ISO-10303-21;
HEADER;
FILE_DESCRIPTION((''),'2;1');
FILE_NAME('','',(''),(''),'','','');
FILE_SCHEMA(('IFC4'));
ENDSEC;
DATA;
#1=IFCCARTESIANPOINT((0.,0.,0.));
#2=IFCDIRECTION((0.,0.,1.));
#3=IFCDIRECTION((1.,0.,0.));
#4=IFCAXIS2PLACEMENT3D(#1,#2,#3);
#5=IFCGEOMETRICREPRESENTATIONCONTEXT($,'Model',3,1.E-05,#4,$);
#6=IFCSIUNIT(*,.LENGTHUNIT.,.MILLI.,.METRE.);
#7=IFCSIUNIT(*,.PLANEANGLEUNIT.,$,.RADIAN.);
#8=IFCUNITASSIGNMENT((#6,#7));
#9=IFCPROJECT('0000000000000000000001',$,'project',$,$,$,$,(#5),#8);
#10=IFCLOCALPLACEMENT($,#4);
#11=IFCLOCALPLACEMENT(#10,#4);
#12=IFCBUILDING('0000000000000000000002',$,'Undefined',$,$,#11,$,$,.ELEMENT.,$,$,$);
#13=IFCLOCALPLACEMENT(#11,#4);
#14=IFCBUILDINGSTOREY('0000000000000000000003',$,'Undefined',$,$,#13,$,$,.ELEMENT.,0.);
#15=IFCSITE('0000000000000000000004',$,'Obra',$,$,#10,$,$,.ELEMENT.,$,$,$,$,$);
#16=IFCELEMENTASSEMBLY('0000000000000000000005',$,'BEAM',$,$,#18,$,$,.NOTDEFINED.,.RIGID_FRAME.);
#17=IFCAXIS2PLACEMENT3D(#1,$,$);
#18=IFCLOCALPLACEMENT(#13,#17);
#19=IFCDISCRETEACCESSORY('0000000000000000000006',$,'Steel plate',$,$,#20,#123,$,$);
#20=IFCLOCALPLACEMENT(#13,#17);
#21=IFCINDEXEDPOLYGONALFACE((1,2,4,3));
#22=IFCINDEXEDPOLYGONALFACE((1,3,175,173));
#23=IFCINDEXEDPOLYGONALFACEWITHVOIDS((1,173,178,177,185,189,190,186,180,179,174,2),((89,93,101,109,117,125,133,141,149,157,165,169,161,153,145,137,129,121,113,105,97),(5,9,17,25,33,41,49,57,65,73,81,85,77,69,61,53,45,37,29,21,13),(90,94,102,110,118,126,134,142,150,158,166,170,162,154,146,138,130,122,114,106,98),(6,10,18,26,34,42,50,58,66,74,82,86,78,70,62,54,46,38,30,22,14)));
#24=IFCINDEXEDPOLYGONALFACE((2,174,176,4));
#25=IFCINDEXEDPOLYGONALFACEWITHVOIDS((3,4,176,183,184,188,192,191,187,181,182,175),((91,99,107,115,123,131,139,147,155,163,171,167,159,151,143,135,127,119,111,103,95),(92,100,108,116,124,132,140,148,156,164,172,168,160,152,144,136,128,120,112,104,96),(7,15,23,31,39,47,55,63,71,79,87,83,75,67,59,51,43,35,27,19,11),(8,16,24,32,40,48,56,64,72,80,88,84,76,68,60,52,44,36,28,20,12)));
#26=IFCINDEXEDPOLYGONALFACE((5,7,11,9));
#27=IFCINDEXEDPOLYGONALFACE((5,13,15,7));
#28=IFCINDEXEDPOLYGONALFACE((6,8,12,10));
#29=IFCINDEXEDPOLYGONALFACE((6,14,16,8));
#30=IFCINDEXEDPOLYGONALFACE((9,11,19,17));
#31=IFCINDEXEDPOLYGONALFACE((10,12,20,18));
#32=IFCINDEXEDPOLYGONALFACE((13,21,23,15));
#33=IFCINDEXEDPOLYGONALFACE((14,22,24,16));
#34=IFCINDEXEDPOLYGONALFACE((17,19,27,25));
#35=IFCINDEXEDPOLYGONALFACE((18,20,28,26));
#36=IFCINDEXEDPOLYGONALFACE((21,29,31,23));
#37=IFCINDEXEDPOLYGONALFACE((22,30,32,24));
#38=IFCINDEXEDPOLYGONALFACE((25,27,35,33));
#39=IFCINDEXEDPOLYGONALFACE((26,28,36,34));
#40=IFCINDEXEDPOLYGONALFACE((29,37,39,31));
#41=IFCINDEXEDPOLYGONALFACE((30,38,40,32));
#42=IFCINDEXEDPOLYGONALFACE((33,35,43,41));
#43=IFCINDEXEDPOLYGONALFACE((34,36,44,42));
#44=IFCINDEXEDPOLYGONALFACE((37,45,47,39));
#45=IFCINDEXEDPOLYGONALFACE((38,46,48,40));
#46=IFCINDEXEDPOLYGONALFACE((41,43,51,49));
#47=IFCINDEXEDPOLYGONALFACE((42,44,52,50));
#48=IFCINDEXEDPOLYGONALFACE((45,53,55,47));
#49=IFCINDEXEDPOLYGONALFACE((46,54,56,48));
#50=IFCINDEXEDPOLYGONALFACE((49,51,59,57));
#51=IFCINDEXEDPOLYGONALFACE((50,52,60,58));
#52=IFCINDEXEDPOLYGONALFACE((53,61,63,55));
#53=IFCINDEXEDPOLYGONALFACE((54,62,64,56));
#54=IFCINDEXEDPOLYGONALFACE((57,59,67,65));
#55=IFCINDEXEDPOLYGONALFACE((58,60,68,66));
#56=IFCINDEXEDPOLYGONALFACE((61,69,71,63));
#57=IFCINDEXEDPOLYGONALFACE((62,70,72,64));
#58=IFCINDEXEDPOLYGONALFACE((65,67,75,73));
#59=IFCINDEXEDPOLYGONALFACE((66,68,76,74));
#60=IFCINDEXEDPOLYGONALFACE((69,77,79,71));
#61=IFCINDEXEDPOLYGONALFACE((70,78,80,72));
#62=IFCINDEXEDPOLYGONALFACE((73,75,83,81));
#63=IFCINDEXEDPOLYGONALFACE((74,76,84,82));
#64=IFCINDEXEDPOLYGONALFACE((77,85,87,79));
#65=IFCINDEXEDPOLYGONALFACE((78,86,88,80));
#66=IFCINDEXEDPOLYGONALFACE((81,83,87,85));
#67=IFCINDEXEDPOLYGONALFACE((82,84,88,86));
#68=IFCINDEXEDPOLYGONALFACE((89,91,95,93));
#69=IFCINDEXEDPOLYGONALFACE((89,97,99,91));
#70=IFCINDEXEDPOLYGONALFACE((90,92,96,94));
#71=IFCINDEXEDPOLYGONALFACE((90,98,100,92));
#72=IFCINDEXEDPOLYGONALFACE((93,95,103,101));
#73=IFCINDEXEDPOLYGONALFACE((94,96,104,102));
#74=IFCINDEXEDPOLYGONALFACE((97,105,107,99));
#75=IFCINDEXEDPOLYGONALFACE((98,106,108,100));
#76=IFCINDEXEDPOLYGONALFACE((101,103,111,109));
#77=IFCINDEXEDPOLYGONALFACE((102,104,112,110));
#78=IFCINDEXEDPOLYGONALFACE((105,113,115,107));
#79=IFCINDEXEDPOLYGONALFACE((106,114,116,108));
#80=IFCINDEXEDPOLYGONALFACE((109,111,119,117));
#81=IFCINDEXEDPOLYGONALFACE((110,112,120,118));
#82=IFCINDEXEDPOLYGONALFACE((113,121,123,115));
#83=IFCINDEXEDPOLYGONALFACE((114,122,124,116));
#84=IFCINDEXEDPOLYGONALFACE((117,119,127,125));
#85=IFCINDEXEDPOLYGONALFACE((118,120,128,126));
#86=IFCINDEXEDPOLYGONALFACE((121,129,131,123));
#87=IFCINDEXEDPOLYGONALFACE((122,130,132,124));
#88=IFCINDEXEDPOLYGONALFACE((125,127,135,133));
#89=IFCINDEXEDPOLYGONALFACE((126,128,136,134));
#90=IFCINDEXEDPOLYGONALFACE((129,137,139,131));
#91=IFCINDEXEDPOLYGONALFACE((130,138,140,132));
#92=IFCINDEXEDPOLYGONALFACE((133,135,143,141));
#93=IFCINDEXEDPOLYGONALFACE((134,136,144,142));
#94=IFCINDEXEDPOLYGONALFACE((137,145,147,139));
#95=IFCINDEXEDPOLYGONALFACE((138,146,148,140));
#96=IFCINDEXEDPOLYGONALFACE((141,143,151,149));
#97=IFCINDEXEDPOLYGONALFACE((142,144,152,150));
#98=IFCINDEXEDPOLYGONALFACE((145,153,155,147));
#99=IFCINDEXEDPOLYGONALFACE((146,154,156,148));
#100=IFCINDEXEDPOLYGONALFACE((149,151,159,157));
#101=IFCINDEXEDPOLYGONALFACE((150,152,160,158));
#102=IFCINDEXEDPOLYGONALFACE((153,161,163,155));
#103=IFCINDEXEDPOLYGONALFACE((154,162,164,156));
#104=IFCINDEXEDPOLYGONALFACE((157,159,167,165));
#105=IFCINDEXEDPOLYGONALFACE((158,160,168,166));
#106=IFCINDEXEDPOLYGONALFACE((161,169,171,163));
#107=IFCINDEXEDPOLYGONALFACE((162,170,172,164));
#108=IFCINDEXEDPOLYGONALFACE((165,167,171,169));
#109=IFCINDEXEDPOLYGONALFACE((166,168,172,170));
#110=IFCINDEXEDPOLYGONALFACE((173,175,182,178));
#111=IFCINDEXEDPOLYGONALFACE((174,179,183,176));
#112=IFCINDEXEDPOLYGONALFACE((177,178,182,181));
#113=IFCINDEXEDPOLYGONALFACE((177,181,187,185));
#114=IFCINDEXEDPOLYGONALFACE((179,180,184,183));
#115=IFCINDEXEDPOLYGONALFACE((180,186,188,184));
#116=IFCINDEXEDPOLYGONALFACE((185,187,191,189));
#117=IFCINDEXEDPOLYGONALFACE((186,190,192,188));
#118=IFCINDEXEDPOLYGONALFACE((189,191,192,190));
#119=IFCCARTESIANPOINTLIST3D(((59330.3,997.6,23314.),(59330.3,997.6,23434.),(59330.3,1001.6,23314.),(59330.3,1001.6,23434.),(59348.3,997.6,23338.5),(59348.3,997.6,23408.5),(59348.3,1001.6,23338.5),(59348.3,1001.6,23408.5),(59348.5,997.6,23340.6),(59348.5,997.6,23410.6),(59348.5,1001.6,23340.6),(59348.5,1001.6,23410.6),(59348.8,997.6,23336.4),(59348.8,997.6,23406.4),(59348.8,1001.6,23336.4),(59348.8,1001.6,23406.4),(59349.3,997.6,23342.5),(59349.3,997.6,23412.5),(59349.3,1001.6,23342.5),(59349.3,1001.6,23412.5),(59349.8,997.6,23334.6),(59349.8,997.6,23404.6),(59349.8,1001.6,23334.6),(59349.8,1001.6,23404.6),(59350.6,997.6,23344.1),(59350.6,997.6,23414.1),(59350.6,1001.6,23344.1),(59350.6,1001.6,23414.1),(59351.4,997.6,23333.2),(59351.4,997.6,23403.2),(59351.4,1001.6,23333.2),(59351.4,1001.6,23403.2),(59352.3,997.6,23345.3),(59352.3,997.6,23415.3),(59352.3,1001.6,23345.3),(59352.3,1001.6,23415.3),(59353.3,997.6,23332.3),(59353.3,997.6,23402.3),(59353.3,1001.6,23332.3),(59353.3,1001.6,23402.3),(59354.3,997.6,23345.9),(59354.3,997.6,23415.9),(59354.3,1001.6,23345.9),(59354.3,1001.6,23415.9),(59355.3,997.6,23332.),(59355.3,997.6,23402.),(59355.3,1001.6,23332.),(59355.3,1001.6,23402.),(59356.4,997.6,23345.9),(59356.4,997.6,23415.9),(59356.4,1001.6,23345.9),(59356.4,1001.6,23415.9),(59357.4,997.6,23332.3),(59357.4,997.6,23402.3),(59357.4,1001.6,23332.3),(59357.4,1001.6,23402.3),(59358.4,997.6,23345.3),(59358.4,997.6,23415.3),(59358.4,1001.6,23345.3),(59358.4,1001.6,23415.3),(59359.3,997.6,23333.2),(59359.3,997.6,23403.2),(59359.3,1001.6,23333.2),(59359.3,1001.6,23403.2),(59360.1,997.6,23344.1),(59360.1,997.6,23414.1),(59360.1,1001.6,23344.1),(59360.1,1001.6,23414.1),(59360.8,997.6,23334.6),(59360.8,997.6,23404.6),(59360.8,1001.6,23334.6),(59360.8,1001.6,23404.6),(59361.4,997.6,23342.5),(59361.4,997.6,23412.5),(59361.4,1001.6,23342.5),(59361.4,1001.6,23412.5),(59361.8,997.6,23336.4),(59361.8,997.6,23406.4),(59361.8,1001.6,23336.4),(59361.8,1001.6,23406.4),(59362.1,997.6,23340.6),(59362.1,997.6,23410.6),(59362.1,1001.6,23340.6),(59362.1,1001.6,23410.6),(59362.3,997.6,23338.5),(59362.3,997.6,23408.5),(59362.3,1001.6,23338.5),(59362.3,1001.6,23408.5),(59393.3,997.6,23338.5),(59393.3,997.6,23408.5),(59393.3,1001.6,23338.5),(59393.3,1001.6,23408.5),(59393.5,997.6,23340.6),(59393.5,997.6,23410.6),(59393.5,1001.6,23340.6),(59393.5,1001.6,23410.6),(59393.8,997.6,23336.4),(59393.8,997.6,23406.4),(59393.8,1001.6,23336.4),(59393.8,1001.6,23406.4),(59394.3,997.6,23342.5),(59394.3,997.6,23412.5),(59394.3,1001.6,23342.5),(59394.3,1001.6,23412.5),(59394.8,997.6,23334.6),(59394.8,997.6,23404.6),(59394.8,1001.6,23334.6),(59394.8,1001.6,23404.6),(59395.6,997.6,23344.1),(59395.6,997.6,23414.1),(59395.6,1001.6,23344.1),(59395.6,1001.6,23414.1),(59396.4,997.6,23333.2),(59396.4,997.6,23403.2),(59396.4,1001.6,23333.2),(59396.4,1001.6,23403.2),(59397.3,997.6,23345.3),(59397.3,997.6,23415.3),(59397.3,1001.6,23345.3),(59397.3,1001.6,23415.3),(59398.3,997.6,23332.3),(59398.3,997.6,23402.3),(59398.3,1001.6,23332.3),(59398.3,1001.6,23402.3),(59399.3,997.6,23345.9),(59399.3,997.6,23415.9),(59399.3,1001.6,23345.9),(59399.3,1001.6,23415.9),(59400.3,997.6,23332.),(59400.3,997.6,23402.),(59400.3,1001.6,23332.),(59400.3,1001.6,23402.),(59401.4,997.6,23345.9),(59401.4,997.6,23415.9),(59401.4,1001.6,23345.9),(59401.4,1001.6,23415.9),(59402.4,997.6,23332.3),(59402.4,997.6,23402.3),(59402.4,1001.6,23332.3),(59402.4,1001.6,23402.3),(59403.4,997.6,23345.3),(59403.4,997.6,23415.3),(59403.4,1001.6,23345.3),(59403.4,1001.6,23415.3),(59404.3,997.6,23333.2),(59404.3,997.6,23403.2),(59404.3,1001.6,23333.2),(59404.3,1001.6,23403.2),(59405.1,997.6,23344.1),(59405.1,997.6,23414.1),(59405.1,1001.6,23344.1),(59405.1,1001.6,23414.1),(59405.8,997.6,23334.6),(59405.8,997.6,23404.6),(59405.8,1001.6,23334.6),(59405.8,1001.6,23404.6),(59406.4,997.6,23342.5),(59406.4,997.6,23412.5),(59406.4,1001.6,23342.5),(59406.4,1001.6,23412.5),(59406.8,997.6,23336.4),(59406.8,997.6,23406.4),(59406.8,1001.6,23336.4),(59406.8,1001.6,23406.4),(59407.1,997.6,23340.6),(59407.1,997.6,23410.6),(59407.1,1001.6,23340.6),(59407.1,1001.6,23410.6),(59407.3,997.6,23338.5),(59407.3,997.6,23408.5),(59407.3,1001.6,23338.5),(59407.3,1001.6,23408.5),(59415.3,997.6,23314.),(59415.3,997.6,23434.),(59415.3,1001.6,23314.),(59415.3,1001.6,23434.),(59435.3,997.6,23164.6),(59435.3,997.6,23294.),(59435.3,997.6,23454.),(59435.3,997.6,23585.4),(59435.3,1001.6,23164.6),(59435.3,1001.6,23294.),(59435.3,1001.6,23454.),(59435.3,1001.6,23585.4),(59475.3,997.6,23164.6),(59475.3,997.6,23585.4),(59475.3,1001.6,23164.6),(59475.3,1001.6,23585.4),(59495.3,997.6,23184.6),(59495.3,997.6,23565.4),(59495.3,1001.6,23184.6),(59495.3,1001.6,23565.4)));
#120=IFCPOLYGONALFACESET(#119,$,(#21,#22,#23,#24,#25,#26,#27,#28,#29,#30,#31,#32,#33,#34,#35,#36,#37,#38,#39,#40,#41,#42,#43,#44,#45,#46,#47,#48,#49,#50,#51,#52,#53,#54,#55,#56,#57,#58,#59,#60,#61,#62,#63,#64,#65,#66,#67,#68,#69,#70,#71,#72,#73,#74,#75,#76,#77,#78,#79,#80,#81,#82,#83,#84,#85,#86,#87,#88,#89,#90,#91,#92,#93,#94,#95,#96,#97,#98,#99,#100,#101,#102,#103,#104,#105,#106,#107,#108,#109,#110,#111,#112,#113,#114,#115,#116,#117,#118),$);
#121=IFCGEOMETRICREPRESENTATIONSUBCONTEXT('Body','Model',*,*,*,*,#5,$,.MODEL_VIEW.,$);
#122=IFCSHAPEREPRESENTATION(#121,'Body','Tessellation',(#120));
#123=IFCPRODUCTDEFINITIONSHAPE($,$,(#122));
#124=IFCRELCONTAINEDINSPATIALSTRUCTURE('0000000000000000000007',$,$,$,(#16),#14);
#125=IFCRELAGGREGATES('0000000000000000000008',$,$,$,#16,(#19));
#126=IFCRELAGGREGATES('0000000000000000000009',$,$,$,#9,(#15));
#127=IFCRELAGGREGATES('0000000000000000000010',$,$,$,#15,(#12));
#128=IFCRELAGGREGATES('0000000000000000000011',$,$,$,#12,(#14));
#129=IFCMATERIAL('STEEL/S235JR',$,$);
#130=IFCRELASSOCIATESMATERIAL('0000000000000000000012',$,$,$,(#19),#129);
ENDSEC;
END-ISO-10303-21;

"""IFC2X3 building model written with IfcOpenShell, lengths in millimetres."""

from ifc_helpers import new_model, si_unit, frame, origin_with_axes, origin_2d_with_axis, place, context, subcontext, project, spatial, polyline, circle, outline, extrude, source, transform, mapped, material, element, aggregate, save


model = new_model("IFC2X3")

# Units and contexts
model_context = context("Model", 3, precision=1e-05, world=origin_with_axes())
body_context = subcontext(model_context, "Body", "Model", "MODEL_VIEW")
ifc_project = project(units=[si_unit("LENGTHUNIT", "METRE", prefix="MILLI"), si_unit("PLANEANGLEUNIT", "RADIAN")], contexts=[model_context])

# Site, building, storey
site_placement = place(None, origin_with_axes())
site = spatial("IfcSite", under=ifc_project, at=site_placement, Name="Obra", CompositionType="ELEMENT")
building_placement = place(site_placement, origin_with_axes())
building = spatial("IfcBuilding", under=site, at=building_placement, Name="Undefined", CompositionType="ELEMENT")
storey_placement = place(building_placement, origin_with_axes())
storey = spatial("IfcBuildingStorey", under=building, at=storey_placement, Name="Undefined", CompositionType="ELEMENT", Elevation=0.0)

# Element assembly
assembly_1_placement = place(storey_placement, origin_with_axes())
assembly_1 = element("IfcElementAssembly", 1, at=assembly_1_placement, inside=storey, Name="BEAM", AssemblyPlace="NOTDEFINED", PredefinedType="RIGID_FRAME")
ifc_material_1 = material(Name="STEEL/S235JR")

# Discrete accessory, opening
discrete_accessory_1_placement = place(assembly_1_placement, frame((59495.3, 999.6, 23184.6), z_axis=(0.000014, 1.0, 0.0), x_axis=(-0.707107, 0.00001, -0.707107)))
discrete_accessory_1 = element("IfcDiscreteAccessory", 2, at=discrete_accessory_1_placement, material=ifc_material_1, Name="Steel plate", context=body_context, shape_type="SweptSolid", body=[
    extrude(outline(polyline([(0.0, 0.0), (28.3, 0.0), (56.6, 28.3), (-34.9, 119.8), (-34.9, 148.1), (25.2, 208.2), (-59.7, 293.0), (-119.8, 232.9), (-148.1, 232.9), (-241.0, 325.8), (-269.3, 297.6), (-269.3, 269.3), (0.0, 0.0)])), frame((0.0, 0.0, -2.0), z_axis=(0.0, 0.0, 1.0), x_axis=(1.0, 0.0, 0.0)), (0.0, 0.0, 1.0), 4.0),
])
shared_shape_1 = source(origin_with_axes(), body_context, "Body", "SweptSolid", [
    extrude(circle(Radius=7.0, at=origin_2d_with_axis()), frame((0.0, 32.4, 0.0), z_axis=(0.0, 1.0, 0.0), x_axis=(1.0, 0.0, 0.0)), (0.0, 0.0, 1.0), 4.2),
])
opening_1_placement = place(assembly_1_placement, frame((59425.3, 1034.1, 23434.0), z_axis=(-1.0, 0.000014, 0.0), x_axis=(0.0, 0.0, -1.0)))
element("IfcOpeningElement", 3, at=opening_1_placement, cuts=discrete_accessory_1, ObjectType="Opening", context=body_context, shape_type="MappedRepresentation", body=[
    mapped(shared_shape_1, transform((25.0, 0.0, 25.0))),
    mapped(shared_shape_1, transform((25.0, 0.0, 70.0))),
    mapped(shared_shape_1, transform((95.0, 0.0, 25.0))),
    mapped(shared_shape_1, transform((95.0, 0.0, 70.0))),
])
aggregate(assembly_1, [discrete_accessory_1])

save(model, "model.ifc")
